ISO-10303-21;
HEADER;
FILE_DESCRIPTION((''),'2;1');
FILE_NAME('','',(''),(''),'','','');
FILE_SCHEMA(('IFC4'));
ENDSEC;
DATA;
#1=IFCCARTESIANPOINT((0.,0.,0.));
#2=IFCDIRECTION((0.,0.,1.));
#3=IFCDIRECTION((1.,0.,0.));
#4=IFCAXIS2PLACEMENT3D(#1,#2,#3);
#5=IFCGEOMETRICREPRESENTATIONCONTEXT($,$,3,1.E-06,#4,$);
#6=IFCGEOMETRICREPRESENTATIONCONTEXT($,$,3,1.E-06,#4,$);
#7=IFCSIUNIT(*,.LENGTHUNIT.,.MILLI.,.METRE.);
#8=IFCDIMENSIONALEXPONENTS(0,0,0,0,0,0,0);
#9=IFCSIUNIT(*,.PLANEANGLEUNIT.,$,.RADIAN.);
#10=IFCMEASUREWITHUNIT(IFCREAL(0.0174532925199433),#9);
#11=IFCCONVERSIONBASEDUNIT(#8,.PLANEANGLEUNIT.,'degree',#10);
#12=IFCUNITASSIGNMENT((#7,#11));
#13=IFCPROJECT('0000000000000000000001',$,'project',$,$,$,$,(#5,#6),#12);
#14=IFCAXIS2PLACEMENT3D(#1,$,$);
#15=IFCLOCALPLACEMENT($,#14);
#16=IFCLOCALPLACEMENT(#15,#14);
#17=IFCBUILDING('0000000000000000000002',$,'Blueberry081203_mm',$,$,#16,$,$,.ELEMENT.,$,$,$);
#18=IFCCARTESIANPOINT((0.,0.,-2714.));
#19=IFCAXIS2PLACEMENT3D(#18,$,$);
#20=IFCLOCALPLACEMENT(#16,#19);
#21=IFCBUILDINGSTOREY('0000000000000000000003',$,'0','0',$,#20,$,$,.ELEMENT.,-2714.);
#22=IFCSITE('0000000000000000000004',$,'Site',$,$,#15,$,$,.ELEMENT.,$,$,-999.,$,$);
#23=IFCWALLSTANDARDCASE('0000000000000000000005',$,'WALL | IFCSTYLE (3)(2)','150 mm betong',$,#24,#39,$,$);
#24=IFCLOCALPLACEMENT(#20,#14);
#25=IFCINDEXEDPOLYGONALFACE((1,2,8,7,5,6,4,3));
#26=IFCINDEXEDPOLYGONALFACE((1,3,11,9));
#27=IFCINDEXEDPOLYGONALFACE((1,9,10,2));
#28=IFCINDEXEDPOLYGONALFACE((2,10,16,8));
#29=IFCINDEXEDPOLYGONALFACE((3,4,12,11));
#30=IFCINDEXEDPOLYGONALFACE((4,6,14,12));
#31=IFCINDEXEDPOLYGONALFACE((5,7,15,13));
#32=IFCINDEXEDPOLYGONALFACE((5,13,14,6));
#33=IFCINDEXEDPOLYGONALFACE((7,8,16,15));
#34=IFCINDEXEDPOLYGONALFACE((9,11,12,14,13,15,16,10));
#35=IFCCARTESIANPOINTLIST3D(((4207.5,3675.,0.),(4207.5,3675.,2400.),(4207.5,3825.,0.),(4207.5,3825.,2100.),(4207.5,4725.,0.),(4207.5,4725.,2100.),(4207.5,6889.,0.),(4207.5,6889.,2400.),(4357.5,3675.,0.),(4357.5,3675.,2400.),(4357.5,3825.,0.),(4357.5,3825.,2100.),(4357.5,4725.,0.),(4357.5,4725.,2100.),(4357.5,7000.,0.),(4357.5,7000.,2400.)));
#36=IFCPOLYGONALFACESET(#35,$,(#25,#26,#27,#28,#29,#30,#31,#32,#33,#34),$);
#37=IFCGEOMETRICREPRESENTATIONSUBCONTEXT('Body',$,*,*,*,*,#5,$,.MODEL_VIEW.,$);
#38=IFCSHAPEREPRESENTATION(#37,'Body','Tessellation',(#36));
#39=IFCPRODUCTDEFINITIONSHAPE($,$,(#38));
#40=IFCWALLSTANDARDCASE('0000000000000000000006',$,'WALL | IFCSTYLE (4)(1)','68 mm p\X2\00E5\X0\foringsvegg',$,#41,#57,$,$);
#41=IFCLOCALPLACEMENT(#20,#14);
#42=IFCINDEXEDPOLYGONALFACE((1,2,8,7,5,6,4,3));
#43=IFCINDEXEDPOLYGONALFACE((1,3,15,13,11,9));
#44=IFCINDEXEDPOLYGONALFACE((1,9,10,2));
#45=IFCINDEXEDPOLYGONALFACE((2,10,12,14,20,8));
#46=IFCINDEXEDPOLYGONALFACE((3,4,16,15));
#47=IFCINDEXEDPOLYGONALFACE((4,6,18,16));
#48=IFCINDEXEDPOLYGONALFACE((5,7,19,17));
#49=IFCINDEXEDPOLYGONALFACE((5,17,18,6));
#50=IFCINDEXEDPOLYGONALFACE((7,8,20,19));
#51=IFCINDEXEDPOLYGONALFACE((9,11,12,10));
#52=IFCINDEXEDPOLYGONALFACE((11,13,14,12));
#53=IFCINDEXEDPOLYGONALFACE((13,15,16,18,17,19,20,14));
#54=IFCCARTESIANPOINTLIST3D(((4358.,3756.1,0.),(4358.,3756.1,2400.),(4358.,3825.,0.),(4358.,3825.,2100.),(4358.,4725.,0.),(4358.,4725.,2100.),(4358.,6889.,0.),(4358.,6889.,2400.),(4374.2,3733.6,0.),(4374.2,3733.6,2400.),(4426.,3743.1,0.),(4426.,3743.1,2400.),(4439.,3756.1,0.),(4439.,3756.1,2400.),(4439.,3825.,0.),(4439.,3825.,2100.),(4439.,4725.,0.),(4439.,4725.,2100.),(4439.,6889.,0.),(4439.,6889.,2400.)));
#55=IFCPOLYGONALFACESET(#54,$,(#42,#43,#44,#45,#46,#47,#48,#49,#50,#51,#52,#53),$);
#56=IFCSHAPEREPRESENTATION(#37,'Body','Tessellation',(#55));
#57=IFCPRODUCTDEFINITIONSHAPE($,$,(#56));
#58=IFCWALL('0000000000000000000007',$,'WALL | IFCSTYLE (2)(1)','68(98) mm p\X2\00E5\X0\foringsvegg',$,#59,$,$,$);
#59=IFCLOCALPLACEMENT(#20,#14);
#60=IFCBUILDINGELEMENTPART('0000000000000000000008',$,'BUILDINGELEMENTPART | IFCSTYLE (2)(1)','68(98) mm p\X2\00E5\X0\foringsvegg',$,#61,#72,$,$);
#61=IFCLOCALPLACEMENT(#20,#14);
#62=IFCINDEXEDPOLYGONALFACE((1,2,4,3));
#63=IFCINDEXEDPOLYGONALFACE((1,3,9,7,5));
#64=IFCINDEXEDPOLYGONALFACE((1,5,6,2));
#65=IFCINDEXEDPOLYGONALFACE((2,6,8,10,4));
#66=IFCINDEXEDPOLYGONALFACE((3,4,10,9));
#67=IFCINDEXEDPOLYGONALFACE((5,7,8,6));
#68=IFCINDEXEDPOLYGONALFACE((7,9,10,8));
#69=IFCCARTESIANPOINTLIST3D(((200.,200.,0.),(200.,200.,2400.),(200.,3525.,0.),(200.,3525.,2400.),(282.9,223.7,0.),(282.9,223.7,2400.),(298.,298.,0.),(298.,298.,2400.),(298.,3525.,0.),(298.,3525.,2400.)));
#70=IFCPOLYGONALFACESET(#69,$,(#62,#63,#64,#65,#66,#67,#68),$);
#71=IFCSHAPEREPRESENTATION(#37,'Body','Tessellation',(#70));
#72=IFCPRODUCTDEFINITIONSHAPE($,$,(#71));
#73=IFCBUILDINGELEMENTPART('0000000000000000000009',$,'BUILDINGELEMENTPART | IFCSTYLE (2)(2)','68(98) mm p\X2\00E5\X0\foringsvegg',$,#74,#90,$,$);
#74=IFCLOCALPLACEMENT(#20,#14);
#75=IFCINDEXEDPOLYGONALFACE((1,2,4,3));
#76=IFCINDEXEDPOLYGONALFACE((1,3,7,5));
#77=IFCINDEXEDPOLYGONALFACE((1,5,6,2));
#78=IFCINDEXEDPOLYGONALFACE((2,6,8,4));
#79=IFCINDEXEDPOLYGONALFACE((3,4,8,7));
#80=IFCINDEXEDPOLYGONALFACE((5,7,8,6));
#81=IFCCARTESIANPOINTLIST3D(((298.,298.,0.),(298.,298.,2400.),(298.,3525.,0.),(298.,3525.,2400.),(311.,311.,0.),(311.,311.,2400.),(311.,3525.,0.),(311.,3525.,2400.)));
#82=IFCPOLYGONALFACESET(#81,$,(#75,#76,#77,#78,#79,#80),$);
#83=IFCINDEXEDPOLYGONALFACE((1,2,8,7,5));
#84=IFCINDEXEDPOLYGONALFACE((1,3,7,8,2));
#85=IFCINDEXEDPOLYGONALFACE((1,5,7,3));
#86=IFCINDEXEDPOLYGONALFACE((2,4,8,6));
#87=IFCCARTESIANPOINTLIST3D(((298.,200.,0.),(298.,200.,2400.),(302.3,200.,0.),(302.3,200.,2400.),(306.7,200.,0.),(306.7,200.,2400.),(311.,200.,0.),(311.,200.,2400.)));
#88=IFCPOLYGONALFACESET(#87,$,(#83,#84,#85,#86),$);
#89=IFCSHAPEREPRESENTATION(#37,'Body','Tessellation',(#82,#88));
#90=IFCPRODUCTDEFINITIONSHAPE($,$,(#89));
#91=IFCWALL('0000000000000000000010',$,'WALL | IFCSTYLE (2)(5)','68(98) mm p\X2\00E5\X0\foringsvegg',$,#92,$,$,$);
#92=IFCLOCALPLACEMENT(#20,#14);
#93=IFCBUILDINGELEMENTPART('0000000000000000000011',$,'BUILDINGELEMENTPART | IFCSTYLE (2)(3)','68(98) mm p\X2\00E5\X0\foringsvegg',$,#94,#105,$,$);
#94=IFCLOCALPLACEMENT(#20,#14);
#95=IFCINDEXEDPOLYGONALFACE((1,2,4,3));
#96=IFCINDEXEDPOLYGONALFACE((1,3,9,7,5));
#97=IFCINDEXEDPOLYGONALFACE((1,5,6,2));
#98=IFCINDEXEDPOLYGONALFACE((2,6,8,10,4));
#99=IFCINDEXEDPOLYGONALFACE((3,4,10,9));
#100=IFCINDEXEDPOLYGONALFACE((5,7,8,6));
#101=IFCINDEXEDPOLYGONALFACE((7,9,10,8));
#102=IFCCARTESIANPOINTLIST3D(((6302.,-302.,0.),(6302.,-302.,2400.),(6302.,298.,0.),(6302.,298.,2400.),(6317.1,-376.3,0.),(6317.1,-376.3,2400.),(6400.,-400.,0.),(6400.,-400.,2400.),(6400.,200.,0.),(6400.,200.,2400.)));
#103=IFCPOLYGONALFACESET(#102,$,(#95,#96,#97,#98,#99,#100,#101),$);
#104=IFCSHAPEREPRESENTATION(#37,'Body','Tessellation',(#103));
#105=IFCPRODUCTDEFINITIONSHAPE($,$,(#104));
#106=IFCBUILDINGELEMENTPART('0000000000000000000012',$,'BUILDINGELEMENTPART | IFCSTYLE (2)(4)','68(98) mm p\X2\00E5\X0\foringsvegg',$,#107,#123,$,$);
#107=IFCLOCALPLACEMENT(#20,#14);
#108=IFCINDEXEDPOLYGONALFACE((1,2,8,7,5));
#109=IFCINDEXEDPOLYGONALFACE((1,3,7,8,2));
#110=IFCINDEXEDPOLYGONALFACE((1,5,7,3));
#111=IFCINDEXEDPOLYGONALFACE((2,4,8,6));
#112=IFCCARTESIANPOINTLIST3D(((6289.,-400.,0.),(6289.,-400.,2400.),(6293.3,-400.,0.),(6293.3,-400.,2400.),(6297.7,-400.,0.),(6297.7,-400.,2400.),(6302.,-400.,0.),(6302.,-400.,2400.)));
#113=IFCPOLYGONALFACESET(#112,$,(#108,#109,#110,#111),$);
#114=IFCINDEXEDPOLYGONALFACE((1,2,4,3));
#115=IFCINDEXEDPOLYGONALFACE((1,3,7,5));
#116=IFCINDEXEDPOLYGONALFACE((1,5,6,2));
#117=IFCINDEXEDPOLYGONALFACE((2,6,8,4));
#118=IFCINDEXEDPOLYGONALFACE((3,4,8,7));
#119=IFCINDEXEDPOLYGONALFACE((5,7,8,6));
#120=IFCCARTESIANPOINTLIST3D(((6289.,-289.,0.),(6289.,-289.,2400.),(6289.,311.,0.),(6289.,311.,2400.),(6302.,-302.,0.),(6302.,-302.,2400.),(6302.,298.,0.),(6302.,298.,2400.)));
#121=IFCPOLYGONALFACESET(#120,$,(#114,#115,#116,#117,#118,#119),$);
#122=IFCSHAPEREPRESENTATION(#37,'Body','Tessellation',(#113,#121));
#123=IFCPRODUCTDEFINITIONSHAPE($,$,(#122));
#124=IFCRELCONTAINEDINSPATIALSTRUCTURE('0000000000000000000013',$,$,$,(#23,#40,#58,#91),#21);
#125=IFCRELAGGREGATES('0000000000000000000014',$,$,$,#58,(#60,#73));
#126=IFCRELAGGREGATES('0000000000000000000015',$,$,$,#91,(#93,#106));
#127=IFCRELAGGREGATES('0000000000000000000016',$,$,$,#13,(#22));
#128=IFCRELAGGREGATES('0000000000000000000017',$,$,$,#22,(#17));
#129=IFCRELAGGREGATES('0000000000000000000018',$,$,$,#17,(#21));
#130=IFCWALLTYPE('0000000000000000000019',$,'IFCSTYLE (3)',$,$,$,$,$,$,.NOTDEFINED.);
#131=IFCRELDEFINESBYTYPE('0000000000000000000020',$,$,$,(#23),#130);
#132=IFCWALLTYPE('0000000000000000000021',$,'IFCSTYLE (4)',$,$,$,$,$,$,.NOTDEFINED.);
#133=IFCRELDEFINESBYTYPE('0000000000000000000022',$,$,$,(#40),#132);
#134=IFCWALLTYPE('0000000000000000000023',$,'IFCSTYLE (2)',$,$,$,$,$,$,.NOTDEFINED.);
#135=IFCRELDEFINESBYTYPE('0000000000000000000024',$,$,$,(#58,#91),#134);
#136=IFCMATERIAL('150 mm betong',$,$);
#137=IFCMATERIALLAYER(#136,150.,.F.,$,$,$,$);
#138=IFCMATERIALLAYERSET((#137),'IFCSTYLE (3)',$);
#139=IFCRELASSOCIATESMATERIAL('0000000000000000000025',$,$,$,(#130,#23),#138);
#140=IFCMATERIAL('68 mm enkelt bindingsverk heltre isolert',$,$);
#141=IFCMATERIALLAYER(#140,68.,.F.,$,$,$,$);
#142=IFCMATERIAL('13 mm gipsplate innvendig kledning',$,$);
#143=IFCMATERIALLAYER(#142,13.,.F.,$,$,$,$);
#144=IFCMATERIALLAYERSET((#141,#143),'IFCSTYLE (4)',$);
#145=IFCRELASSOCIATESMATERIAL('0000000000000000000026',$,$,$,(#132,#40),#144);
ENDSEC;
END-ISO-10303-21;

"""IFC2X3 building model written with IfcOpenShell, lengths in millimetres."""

from ifc_helpers import new_model, entity, si_unit, converted_unit, frame, frame_2d, origin, origin_with_axes, origin_2d_with_axis, place, context, subcontext, project, spatial, polyline, segment, composite_curve, rectangle, outline, extrude, material, layer, layer_set, layer_usage, type_object, element, aggregate, save


model = new_model("IFC2X3")

# Units and contexts
context_of_model_1 = context(None, 3, precision=1e-06, world=origin_with_axes())
context_of_model_2 = context(None, 3, precision=1e-06, world=origin_with_axes())
body_context = subcontext(context_of_model_1, "Body", None, "MODEL_VIEW")
ifc_project = project(units=[si_unit("LENGTHUNIT", "METRE", prefix="MILLI"), converted_unit("PLANEANGLEUNIT", "degree", entity("IfcReal", 0.0174532925199433), si_unit("PLANEANGLEUNIT", "RADIAN"), dimensions=[0, 0, 0, 0, 0, 0, 0])], contexts=[context_of_model_1, context_of_model_2])

# Site, building, storey
site_placement = place(None, origin())
site = spatial("IfcSite", under=ifc_project, at=site_placement, Name="Site", CompositionType="ELEMENT", RefElevation=-999.0)
building_placement = place(site_placement, origin())
building = spatial("IfcBuilding", under=site, at=building_placement, Name="Blueberry081203_mm", CompositionType="ELEMENT")
storey_placement = place(building_placement, frame((0.0, 0.0, -2714.0)))
storey = spatial("IfcBuildingStorey", under=building, at=storey_placement, Name="0", Description="0", CompositionType="ELEMENT", Elevation=-2714.0)

# Shared definitions
wall_type_1 = type_object("IfcWallType", Name="IFCSTYLE (2)", PredefinedType="NOTDEFINED")

# Walls, openings
ifc_material_1 = material(Name="150 mm betong")
ifc_layer_1 = layer(ifc_material_1, 150.0, ventilated=False)
ifc_layer_set_1 = layer_set([ifc_layer_1], Name="IFCSTYLE (3)")
wall_type_2 = type_object("IfcWallType", Name="IFCSTYLE (3)", PredefinedType="NOTDEFINED", material=ifc_layer_set_1)
ifc_layer_usage_1 = layer_usage(ifc_layer_set_1, "AXIS2", "POSITIVE", 0.0)
wall_1_placement = place(storey_placement, frame((4207.5, 7000.0, 0.0), z_axis=(0.0, 0.0, 1.0), x_axis=(0.0, -1.0, 0.0)))
wall_1 = element("IfcWallStandardCase", 1, at=wall_1_placement, inside=storey, type_object=wall_type_2, material=ifc_layer_usage_1, Name="WALL | IFCSTYLE (3)(2)", Description="150 mm betong", context=body_context, shape_type="SweptSolid", held_by="IfcProductRepresentation", body=[
    extrude(outline(composite_curve([segment(polyline([(0.0, 150.0), (111.0, 0.0)]), True, "CONTINUOUS"), segment(polyline([(111.0, 0.0), (3325.0, 0.0)]), True, "CONTINUOUS"), segment(polyline([(3325.0, 0.0), (3325.0, 150.0)]), True, "CONTINUOUS"), segment(polyline([(3325.0, 150.0), (0.0, 150.0)]), True, "CONTINUOUS")], self_intersect=False)), origin(), (0.0, 0.0, 1.0), 2400.0),
])
opening_1_placement = place(wall_1_placement, frame((2275.0, 75.0, 0.0)))
element("IfcOpeningElement", 2, at=opening_1_placement, cuts=wall_1, context=body_context, shape_type="SweptSolid", held_by="IfcProductRepresentation", body=[
    extrude(rectangle(XDim=900.0, YDim=2100.0, at=origin_2d_with_axis()), frame((450.0, 75.0, 1050.0), z_axis=(0.0, -1.0, 0.0), x_axis=(1.0, 0.0, 0.0)), (0.0, 0.0, 1.0), 150.0),
])
ifc_material_2 = material(Name="68 mm enkelt bindingsverk heltre isolert")
ifc_layer_2 = layer(ifc_material_2, 68.0, ventilated=False)
ifc_material_3 = material(Name="13 mm gipsplate innvendig kledning")
ifc_layer_3 = layer(ifc_material_3, 13.0, ventilated=False)
ifc_layer_set_2 = layer_set([ifc_layer_2, ifc_layer_3], Name="IFCSTYLE (4)")
ifc_layer_usage_2 = layer_usage(ifc_layer_set_2, "AXIS2", "POSITIVE", 0.0)
wall_type_3 = type_object("IfcWallType", Name="IFCSTYLE (4)", PredefinedType="NOTDEFINED", material=ifc_layer_set_2)
wall_2_placement = place(storey_placement, frame((4358.0, 6889.0, 0.0), z_axis=(0.0, 0.0, 1.0), x_axis=(0.0, -1.0, 0.0)))
wall_2 = element("IfcWallStandardCase", 3, at=wall_2_placement, inside=storey, type_object=wall_type_3, material=ifc_layer_usage_2, Name="WALL | IFCSTYLE (4)(1)", Description="68 mm påforingsvegg", context=body_context, shape_type="SweptSolid", held_by="IfcProductRepresentation", body=[
    extrude(outline(composite_curve([segment(polyline([(0.0, 68.0), (0.0, 0.0)]), True, "CONTINUOUS"), segment(polyline([(0.0, 0.0), (3132.9, 0.0)]), True, "CONTINUOUS"), segment(polyline([(3132.9, 0.0), (3155.4, 16.2)]), True, "CONTINUOUS"), segment(polyline([(3155.4, 16.2), (3145.9, 68.0)]), True, "CONTINUOUS"), segment(polyline([(3145.9, 68.0), (3132.9, 81.0)]), True, "CONTINUOUS"), segment(polyline([(3132.9, 81.0), (0.0, 81.0)]), True, "CONTINUOUS"), segment(polyline([(0.0, 81.0), (0.0, 68.0)]), True, "CONTINUOUS")], self_intersect=False)), origin(), (0.0, 0.0, 1.0), 2400.0),
])
opening_2_placement = place(wall_2_placement, frame((2164.0, 40.5, 0.0)))
element("IfcOpeningElement", 4, at=opening_2_placement, cuts=wall_2, context=body_context, shape_type="SweptSolid", held_by="IfcProductRepresentation", body=[
    extrude(rectangle(XDim=900.0, YDim=2100.0, at=origin_2d_with_axis()), frame((450.0, 40.5, 1050.0), z_axis=(0.0, -1.0, 0.0), x_axis=(1.0, 0.0, 0.0)), (0.0, 0.0, 1.0), 81.0),
])

# Walls, building element parts
wall_3_placement = place(storey_placement, frame((200.0, 3525.0, 0.0), z_axis=(0.0, 0.0, 1.0), x_axis=(0.0, -1.0, 0.0)))
wall_3 = element("IfcWall", 5, at=wall_3_placement, inside=storey, type_object=wall_type_1, Name="WALL | IFCSTYLE (2)(1)", Description="68(98) mm påforingsvegg")
building_element_part_1_placement = place(wall_3_placement, origin())
building_element_part_1 = element("IfcBuildingElementPart", 6, at=building_element_part_1_placement, Name="BUILDINGELEMENTPART | IFCSTYLE (2)(1)", Description="68(98) mm påforingsvegg", context=body_context, shape_type="SweptSolid", held_by="IfcProductRepresentation", body=[
    extrude(outline(composite_curve([segment(polyline([(0.0, 98.0), (0.0, 0.0)]), True, "CONTINUOUS"), segment(polyline([(0.0, 0.0), (3325.0, 0.0)]), True, "CONTINUOUS"), segment(polyline([(3325.0, 0.0), (3301.3, 82.9)]), True, "CONTINUOUS"), segment(polyline([(3301.3, 82.9), (3227.0, 98.0)]), True, "CONTINUOUS"), segment(polyline([(3227.0, 98.0), (0.0, 98.0)]), True, "CONTINUOUS")], self_intersect=False)), origin(), (0.0, 0.0, 1.0), 2400.0),
    extrude(rectangle(XDim=98.0, YDim=0.0, at=frame_2d((3325.0, 49.0), x_axis=(0.0, -1.0))), origin(), (0.0, 0.0, 1.0), 2400.0),
])
building_element_part_2_placement = place(wall_3_placement, origin())
building_element_part_2 = element("IfcBuildingElementPart", 7, at=building_element_part_2_placement, Name="BUILDINGELEMENTPART | IFCSTYLE (2)(2)", Description="68(98) mm påforingsvegg", context=body_context, shape_type="SweptSolid", held_by="IfcProductRepresentation", body=[
    extrude(outline(composite_curve([segment(polyline([(0.0, 111.0), (0.0, 98.0)]), True, "CONTINUOUS"), segment(polyline([(0.0, 98.0), (3227.0, 98.0)]), True, "CONTINUOUS"), segment(polyline([(3227.0, 98.0), (3214.0, 111.0)]), True, "CONTINUOUS"), segment(polyline([(3214.0, 111.0), (0.0, 111.0)]), True, "CONTINUOUS")], self_intersect=False)), origin(), (0.0, 0.0, 1.0), 2400.0),
    extrude(outline(composite_curve([segment(polyline([(3325.0, 98.0), (3325.0, 98.0)]), True, "CONTINUOUS"), segment(polyline([(3325.0, 98.0), (3325.0, 111.0)]), True, "CONTINUOUS"), segment(polyline([(3325.0, 111.0), (3325.0, 111.0)]), True, "CONTINUOUS"), segment(polyline([(3325.0, 111.0), (3325.0, 98.0)]), True, "CONTINUOUS")], self_intersect=False)), origin(), (0.0, 0.0, 1.0), 2400.0),
])
aggregate(wall_3, [building_element_part_1, building_element_part_2])
wall_4_placement = place(storey_placement, frame((6400.0, -400.0, 0.0), z_axis=(0.0, 0.0, 1.0), x_axis=(0.0, 1.0, 0.0)))
wall_4 = element("IfcWall", 8, at=wall_4_placement, inside=storey, type_object=wall_type_1, Name="WALL | IFCSTYLE (2)(5)", Description="68(98) mm påforingsvegg")
building_element_part_3_placement = place(wall_4_placement, origin())
building_element_part_3 = element("IfcBuildingElementPart", 9, at=building_element_part_3_placement, Name="BUILDINGELEMENTPART | IFCSTYLE (2)(3)", Description="68(98) mm påforingsvegg", context=body_context, shape_type="SweptSolid", held_by="IfcProductRepresentation", body=[
    extrude(rectangle(XDim=98.0, YDim=0.0, at=frame_2d((0.0, 49.0), x_axis=(0.0, -1.0))), origin(), (0.0, 0.0, 1.0), 2400.0),
    extrude(outline(composite_curve([segment(polyline([(98.0, 98.0), (23.7, 82.9)]), True, "CONTINUOUS"), segment(polyline([(23.7, 82.9), (0.0, 0.0)]), True, "CONTINUOUS"), segment(polyline([(0.0, 0.0), (600.0, 0.0)]), True, "CONTINUOUS"), segment(polyline([(600.0, 0.0), (698.0, 98.0)]), True, "CONTINUOUS"), segment(polyline([(698.0, 98.0), (98.0, 98.0)]), True, "CONTINUOUS")], self_intersect=False)), origin(), (0.0, 0.0, 1.0), 2400.0),
])
building_element_part_4_placement = place(wall_4_placement, origin())
building_element_part_4 = element("IfcBuildingElementPart", 10, at=building_element_part_4_placement, Name="BUILDINGELEMENTPART | IFCSTYLE (2)(4)", Description="68(98) mm påforingsvegg", context=body_context, shape_type="SweptSolid", held_by="IfcProductRepresentation", body=[
    extrude(outline(composite_curve([segment(polyline([(0.0, 111.0), (0.0, 98.0)]), True, "CONTINUOUS"), segment(polyline([(0.0, 98.0), (0.0, 98.0)]), True, "CONTINUOUS"), segment(polyline([(0.0, 98.0), (0.0, 111.0)]), True, "CONTINUOUS"), segment(polyline([(0.0, 111.0), (0.0, 111.0)]), True, "CONTINUOUS")], self_intersect=False)), origin(), (0.0, 0.0, 1.0), 2400.0),
    extrude(outline(composite_curve([segment(polyline([(111.0, 111.0), (98.0, 98.0)]), True, "CONTINUOUS"), segment(polyline([(98.0, 98.0), (698.0, 98.0)]), True, "CONTINUOUS"), segment(polyline([(698.0, 98.0), (711.0, 111.0)]), True, "CONTINUOUS"), segment(polyline([(711.0, 111.0), (111.0, 111.0)]), True, "CONTINUOUS")], self_intersect=False)), origin(), (0.0, 0.0, 1.0), 2400.0),
])
aggregate(wall_4, [building_element_part_3, building_element_part_4])

save(model, "model.ifc")
